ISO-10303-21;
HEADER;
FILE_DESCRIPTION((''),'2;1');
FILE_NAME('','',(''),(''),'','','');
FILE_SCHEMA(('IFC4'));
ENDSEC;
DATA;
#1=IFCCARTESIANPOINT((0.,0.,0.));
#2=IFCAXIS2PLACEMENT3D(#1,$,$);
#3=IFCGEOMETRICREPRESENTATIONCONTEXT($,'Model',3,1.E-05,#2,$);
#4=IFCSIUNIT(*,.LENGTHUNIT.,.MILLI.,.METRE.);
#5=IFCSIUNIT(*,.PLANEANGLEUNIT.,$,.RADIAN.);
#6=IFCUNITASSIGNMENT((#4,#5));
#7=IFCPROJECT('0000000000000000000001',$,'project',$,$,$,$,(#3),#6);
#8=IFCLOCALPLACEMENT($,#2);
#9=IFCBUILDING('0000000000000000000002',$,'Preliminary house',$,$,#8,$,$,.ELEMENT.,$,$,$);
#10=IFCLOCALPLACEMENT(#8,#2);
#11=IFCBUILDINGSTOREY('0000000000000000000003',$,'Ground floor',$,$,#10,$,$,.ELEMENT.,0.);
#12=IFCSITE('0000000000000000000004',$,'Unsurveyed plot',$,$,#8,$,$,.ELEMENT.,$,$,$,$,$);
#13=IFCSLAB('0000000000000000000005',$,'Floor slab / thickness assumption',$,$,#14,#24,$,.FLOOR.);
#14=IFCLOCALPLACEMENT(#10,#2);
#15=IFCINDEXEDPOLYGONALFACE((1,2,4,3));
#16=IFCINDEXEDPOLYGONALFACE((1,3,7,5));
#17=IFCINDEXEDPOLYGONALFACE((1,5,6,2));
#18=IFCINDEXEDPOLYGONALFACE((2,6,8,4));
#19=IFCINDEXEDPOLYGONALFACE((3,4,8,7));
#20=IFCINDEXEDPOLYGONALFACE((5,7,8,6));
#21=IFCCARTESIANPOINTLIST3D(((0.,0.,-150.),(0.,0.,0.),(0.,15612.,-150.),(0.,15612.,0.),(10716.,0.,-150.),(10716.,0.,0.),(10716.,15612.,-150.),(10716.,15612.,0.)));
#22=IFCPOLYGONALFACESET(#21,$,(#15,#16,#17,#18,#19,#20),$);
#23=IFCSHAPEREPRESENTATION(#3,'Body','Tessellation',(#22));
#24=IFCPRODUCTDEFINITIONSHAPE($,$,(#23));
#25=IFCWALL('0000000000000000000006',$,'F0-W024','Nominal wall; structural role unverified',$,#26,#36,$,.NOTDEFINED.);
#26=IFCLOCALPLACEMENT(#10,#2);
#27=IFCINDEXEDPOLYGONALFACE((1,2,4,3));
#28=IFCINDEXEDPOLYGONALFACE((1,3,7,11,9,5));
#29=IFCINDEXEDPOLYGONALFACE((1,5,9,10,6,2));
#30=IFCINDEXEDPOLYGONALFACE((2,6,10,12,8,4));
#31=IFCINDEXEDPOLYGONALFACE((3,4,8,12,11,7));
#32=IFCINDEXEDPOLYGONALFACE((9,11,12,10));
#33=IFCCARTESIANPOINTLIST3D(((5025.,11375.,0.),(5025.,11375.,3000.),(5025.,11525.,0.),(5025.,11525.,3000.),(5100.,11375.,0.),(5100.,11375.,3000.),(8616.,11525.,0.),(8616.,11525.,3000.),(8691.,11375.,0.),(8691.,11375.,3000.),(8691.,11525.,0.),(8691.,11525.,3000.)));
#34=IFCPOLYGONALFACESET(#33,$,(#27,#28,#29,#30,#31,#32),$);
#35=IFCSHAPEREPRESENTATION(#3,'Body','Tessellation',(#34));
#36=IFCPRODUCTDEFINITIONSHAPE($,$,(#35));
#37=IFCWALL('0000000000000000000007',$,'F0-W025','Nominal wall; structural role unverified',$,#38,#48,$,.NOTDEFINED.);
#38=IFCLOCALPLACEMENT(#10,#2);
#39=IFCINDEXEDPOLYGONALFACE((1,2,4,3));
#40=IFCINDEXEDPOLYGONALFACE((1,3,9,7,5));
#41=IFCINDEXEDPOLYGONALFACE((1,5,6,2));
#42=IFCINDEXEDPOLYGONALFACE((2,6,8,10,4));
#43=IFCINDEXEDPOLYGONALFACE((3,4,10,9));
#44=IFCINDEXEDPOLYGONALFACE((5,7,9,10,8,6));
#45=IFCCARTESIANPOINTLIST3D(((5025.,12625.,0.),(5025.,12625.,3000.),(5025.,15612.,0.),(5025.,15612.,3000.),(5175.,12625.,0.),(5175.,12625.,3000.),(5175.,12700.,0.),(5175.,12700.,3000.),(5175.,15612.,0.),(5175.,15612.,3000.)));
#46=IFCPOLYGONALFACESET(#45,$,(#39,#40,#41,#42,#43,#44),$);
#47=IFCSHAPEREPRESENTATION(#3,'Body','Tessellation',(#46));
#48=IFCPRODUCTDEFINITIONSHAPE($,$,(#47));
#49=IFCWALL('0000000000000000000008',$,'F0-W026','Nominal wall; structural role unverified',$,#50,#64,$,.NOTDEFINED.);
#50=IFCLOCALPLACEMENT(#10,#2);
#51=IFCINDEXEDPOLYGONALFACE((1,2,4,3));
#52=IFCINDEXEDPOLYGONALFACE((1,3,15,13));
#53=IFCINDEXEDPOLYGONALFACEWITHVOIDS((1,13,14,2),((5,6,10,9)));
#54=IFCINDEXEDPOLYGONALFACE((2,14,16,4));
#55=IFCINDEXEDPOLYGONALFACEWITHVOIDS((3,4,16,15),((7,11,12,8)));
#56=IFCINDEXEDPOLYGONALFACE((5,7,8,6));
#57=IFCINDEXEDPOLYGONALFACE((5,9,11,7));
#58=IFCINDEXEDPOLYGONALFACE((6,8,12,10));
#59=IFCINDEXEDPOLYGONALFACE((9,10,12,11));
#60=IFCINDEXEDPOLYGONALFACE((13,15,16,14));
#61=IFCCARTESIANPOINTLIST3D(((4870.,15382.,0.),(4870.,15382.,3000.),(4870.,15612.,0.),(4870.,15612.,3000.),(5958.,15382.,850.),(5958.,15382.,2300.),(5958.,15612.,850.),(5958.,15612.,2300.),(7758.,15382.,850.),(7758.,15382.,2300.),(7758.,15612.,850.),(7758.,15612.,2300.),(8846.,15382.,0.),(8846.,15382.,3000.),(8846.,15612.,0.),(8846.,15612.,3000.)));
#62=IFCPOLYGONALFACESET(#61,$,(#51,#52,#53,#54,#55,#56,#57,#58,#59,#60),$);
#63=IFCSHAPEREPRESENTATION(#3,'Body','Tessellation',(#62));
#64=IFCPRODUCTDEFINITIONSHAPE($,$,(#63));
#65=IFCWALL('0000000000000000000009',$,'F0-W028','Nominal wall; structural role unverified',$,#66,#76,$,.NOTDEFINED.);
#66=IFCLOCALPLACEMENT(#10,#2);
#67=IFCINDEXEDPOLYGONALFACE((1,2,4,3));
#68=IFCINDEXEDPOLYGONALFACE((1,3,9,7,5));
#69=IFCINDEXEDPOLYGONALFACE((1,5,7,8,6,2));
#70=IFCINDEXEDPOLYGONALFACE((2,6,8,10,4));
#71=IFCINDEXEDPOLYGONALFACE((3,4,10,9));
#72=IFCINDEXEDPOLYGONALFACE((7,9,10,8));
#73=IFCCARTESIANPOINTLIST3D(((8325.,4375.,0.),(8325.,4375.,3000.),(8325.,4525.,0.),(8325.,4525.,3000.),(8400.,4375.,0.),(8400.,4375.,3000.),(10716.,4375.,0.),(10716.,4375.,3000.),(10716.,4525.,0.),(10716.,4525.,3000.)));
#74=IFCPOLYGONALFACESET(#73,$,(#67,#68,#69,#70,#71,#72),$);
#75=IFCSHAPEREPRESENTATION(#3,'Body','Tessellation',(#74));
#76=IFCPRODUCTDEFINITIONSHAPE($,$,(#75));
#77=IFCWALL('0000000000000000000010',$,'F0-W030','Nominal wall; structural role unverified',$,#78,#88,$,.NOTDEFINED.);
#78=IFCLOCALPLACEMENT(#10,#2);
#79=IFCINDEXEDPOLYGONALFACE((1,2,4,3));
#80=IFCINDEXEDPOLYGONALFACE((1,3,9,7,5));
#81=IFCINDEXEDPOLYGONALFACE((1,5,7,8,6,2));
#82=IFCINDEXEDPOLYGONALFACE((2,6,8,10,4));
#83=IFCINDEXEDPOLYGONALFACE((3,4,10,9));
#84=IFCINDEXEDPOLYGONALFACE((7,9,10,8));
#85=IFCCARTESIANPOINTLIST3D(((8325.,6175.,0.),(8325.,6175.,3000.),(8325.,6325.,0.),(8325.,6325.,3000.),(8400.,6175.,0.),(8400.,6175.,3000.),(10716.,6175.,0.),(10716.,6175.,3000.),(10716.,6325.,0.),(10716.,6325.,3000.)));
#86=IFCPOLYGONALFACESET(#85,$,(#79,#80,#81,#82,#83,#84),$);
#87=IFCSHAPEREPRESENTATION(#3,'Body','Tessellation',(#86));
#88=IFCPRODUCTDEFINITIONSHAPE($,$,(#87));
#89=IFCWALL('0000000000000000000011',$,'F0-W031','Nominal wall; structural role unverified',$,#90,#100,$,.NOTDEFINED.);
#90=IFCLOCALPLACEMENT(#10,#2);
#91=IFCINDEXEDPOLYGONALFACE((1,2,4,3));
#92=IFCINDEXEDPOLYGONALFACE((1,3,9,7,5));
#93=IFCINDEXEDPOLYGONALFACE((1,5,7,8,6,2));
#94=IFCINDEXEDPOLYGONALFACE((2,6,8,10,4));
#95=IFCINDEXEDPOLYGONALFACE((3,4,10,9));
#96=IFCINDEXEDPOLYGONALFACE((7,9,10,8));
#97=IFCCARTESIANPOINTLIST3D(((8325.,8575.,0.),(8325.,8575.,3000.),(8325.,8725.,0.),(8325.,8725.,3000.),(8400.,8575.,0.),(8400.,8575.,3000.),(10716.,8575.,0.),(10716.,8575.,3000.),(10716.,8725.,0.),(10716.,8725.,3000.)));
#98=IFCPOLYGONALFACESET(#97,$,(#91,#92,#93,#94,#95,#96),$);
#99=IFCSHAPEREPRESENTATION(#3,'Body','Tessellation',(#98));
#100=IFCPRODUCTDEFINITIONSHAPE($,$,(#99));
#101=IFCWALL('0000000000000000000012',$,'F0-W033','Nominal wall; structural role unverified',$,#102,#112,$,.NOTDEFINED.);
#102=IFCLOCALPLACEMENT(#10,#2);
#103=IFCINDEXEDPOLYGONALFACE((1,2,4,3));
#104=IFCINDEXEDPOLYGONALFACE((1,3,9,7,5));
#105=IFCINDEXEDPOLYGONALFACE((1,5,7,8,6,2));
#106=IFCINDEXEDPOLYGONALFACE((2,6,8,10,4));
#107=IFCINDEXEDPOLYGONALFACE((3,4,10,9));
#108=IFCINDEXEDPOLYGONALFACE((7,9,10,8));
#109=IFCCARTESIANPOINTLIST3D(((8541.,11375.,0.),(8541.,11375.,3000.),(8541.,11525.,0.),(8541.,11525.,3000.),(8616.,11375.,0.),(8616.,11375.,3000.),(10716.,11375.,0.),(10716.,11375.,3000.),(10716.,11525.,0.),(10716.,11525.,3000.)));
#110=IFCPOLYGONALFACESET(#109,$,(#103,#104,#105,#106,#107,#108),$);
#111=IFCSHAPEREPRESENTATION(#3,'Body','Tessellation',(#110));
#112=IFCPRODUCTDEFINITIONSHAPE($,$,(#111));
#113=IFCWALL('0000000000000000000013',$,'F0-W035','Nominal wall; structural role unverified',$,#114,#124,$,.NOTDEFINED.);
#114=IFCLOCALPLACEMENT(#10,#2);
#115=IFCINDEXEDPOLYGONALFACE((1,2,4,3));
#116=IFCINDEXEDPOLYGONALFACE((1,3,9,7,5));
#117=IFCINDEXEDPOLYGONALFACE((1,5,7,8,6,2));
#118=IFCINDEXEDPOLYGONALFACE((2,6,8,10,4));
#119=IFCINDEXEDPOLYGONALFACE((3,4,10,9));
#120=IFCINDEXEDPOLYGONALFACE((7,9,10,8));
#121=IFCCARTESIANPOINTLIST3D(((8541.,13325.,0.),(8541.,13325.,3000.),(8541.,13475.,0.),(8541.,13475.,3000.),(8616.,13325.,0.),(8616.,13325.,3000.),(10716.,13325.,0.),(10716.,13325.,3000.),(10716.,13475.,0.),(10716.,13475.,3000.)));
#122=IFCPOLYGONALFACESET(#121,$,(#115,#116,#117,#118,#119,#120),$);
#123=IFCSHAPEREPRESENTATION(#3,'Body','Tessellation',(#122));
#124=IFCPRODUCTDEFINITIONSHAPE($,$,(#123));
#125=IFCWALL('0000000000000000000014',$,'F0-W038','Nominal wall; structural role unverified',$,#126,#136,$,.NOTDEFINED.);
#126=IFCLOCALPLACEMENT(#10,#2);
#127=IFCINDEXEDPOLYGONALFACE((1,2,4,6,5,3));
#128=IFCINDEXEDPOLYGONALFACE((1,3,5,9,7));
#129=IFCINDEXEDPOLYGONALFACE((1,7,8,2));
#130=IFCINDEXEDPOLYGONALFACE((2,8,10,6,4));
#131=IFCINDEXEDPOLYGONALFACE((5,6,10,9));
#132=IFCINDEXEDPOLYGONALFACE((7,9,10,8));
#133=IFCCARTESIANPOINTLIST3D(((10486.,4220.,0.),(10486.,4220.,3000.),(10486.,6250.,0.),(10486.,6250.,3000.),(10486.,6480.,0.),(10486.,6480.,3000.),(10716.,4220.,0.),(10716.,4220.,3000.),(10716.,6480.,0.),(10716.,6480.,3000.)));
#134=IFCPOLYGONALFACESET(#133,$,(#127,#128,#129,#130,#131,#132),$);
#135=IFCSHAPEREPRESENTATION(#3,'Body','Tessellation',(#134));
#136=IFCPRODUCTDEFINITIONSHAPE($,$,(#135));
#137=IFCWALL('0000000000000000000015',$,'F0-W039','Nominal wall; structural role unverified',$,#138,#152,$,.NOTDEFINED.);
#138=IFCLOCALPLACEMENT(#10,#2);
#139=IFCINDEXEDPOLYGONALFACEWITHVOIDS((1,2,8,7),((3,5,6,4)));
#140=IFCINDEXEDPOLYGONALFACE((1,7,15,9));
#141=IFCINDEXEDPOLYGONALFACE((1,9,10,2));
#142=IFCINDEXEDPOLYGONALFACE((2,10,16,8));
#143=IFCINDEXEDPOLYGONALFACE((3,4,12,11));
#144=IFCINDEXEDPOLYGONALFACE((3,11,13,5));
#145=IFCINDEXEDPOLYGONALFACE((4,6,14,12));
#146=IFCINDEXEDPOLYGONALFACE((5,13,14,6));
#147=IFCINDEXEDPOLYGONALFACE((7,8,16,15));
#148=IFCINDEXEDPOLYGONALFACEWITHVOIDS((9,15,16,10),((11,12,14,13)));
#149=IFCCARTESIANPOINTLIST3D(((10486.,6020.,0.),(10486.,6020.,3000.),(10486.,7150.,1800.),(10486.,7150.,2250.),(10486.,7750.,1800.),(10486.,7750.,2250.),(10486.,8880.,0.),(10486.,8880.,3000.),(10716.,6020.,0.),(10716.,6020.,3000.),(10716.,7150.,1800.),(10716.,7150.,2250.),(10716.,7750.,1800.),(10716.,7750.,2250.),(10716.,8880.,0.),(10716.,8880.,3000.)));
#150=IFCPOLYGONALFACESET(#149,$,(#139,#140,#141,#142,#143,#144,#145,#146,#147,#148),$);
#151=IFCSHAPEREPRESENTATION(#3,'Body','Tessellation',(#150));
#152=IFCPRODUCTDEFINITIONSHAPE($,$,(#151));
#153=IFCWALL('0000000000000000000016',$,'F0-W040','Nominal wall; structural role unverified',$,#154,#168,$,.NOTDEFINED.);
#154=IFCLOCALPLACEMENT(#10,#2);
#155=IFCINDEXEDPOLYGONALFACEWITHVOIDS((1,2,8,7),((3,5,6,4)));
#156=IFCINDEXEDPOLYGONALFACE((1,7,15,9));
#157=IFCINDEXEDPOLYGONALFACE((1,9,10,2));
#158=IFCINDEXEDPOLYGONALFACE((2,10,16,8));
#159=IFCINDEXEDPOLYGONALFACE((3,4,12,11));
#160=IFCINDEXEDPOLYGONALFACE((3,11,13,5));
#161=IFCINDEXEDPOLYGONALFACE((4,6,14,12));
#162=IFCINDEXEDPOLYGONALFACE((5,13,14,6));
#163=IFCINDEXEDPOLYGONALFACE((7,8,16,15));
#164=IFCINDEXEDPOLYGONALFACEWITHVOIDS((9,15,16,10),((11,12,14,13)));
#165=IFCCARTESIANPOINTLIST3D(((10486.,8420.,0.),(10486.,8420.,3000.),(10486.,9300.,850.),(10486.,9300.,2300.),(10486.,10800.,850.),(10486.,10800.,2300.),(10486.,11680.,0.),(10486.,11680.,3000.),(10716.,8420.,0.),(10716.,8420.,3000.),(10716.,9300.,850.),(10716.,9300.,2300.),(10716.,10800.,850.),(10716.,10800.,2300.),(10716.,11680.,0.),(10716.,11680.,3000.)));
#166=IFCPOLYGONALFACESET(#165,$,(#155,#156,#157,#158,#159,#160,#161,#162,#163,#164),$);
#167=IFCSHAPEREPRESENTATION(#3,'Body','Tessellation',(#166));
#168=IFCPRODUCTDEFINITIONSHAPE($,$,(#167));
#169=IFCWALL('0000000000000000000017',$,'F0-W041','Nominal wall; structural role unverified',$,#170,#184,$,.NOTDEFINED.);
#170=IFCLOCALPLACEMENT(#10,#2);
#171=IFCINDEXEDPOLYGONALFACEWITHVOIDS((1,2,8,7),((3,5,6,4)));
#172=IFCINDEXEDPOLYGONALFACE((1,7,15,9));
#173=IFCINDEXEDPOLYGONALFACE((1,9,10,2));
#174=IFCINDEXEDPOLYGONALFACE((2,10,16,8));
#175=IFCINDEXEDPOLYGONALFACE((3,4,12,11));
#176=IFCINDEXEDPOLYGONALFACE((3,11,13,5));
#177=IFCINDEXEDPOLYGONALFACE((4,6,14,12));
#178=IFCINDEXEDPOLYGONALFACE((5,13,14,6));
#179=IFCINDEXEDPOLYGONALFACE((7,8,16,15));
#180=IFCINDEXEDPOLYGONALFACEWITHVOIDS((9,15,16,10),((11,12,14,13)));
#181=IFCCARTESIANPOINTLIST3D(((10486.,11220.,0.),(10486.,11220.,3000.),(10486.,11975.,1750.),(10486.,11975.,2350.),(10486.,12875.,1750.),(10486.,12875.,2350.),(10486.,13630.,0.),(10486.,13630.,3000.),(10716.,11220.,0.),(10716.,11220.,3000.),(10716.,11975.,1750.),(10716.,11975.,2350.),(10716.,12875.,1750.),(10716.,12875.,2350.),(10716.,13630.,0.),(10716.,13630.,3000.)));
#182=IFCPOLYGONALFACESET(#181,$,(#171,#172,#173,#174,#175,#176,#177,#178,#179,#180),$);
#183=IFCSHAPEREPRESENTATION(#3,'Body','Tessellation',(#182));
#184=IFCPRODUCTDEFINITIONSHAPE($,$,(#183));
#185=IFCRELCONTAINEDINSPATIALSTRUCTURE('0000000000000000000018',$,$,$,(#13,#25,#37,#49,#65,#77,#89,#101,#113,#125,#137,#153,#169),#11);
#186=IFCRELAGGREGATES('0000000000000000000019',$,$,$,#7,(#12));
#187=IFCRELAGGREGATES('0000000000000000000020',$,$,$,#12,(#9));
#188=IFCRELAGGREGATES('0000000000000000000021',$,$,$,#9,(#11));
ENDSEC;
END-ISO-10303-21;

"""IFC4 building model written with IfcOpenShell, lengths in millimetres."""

from ifc_helpers import new_model, si_unit, frame, origin, place, context, project, spatial, polyline, outline, extrude, element, save


model = new_model("IFC4")

# Units and contexts
model_context = context("Model", 3, precision=1e-05, world=origin())
ifc_project = project(units=[si_unit("LENGTHUNIT", "METRE", prefix="MILLI"), si_unit("PLANEANGLEUNIT", "RADIAN")], contexts=[model_context])

# Site, building, storey
placement_1 = place(None, origin())
site = spatial("IfcSite", under=ifc_project, at=placement_1, Name="Unsurveyed plot", CompositionType="ELEMENT")
building = spatial("IfcBuilding", under=site, at=placement_1, Name="Preliminary house", CompositionType="ELEMENT")
placement_2 = place(placement_1, origin())
storey = spatial("IfcBuildingStorey", under=building, at=placement_2, Name="Ground floor", CompositionType="ELEMENT", Elevation=0.0)

# Slab
element("IfcSlab", 1, at=placement_2, inside=storey, Name="Floor slab / thickness assumption", PredefinedType="FLOOR", context=model_context, shape_type="SweptSolid", body=[
    extrude(outline(polyline([(10716.0, 0.0), (10716.0, 15612.0), (0.0, 15612.0), (0.0, 0.0), (10716.0, 0.0)])), frame((0.0, 0.0, -150.0)), (0.0, 0.0, 1.0), 150.0),
])

# Walls
element("IfcWall", 2, at=placement_2, inside=storey, Name="F0-W024", Description="Nominal wall; structural role unverified", PredefinedType="NOTDEFINED", context=model_context, shape_type="SweptSolid", body=[
    extrude(outline(polyline([(8691.0, 11525.0), (8691.0, 11375.0), (5100.0, 11375.0), (5025.0, 11375.0), (5025.0, 11525.0), (8616.0, 11525.0), (8691.0, 11525.0)])), origin(), (0.0, 0.0, 1.0), 3000.0),
])
element("IfcWall", 3, at=placement_2, inside=storey, Name="F0-W025", Description="Nominal wall; structural role unverified", PredefinedType="NOTDEFINED", context=model_context, shape_type="SweptSolid", body=[
    extrude(outline(polyline([(5175.0, 12700.0), (5175.0, 12625.0), (5025.0, 12625.0), (5025.0, 15612.0), (5175.0, 15612.0), (5175.0, 12700.0)])), origin(), (0.0, 0.0, 1.0), 3000.0),
])

# Wall, opening
wall_1 = element("IfcWall", 4, at=placement_2, inside=storey, Name="F0-W026", Description="Nominal wall; structural role unverified", PredefinedType="NOTDEFINED", context=model_context, shape_type="SweptSolid", body=[
    extrude(outline(polyline([(8846.0, 15382.0), (5100.0, 15382.0), (4870.0, 15382.0), (4870.0, 15612.0), (8846.0, 15612.0), (8846.0, 15382.0)])), origin(), (0.0, 0.0, 1.0), 3000.0),
])
element("IfcOpeningElement", 5, at=placement_2, cuts=wall_1, PredefinedType="OPENING", context=model_context, shape_type="SweptSolid", body=[
    extrude(outline(polyline([(5958.0, 14967.0), (7758.0, 14967.0), (7758.0, 16027.0), (5958.0, 16027.0), (5958.0, 14967.0)])), frame((0.0, 0.0, 850.0)), (0.0, 0.0, 1.0), 1450.0),
])

# Wall
element("IfcWall", 6, at=placement_2, inside=storey, Name="F0-W028", Description="Nominal wall; structural role unverified", PredefinedType="NOTDEFINED", context=model_context, shape_type="SweptSolid", body=[
    extrude(outline(polyline([(8400.0, 4375.0), (8325.0, 4375.0), (8325.0, 4525.0), (10716.0, 4525.0), (10716.0, 4375.0), (8400.0, 4375.0)])), origin(), (0.0, 0.0, 1.0), 3000.0),
])

# Walls
element("IfcWall", 7, at=placement_2, inside=storey, Name="F0-W030", Description="Nominal wall; structural role unverified", PredefinedType="NOTDEFINED", context=model_context, shape_type="SweptSolid", body=[
    extrude(outline(polyline([(8400.0, 6175.0), (8325.0, 6175.0), (8325.0, 6325.0), (10716.0, 6325.0), (10716.0, 6175.0), (8400.0, 6175.0)])), origin(), (0.0, 0.0, 1.0), 3000.0),
])
element("IfcWall", 8, at=placement_2, inside=storey, Name="F0-W031", Description="Nominal wall; structural role unverified", PredefinedType="NOTDEFINED", context=model_context, shape_type="SweptSolid", body=[
    extrude(outline(polyline([(8400.0, 8575.0), (8325.0, 8575.0), (8325.0, 8725.0), (10716.0, 8725.0), (10716.0, 8575.0), (8400.0, 8575.0)])), origin(), (0.0, 0.0, 1.0), 3000.0),
])

# Wall
element("IfcWall", 9, at=placement_2, inside=storey, Name="F0-W033", Description="Nominal wall; structural role unverified", PredefinedType="NOTDEFINED", context=model_context, shape_type="SweptSolid", body=[
    extrude(outline(polyline([(8616.0, 11375.0), (8541.0, 11375.0), (8541.0, 11525.0), (10716.0, 11525.0), (10716.0, 11375.0), (8616.0, 11375.0)])), origin(), (0.0, 0.0, 1.0), 3000.0),
])

# Wall
element("IfcWall", 10, at=placement_2, inside=storey, Name="F0-W035", Description="Nominal wall; structural role unverified", PredefinedType="NOTDEFINED", context=model_context, shape_type="SweptSolid", body=[
    extrude(outline(polyline([(8616.0, 13325.0), (8541.0, 13325.0), (8541.0, 13475.0), (10716.0, 13475.0), (10716.0, 13325.0), (8616.0, 13325.0)])), origin(), (0.0, 0.0, 1.0), 3000.0),
])

# Wall
element("IfcWall", 11, at=placement_2, inside=storey, Name="F0-W038", Description="Nominal wall; structural role unverified", PredefinedType="NOTDEFINED", context=model_context, shape_type="SweptSolid", body=[
    extrude(outline(polyline([(10486.0, 6480.0), (10716.0, 6480.0), (10716.0, 4220.0), (10486.0, 4220.0), (10486.0, 6250.0), (10486.0, 6480.0)])), origin(), (0.0, 0.0, 1.0), 3000.0),
])

# Walls, openings
wall_2 = element("IfcWall", 12, at=placement_2, inside=storey, Name="F0-W039", Description="Nominal wall; structural role unverified", PredefinedType="NOTDEFINED", context=model_context, shape_type="SweptSolid", body=[
    extrude(outline(polyline([(10486.0, 8880.0), (10716.0, 8880.0), (10716.0, 6020.0), (10486.0, 6020.0), (10486.0, 8650.0), (10486.0, 8880.0)])), origin(), (0.0, 0.0, 1.0), 3000.0),
])
element("IfcOpeningElement", 13, at=placement_2, cuts=wall_2, PredefinedType="OPENING", context=model_context, shape_type="SweptSolid", body=[
    extrude(outline(polyline([(11131.0, 7150.0), (11131.0, 7750.0), (10071.0, 7750.0), (10071.0, 7150.0), (11131.0, 7150.0)])), frame((0.0, 0.0, 1800.0)), (0.0, 0.0, 1.0), 450.0),
])
wall_3 = element("IfcWall", 14, at=placement_2, inside=storey, Name="F0-W040", Description="Nominal wall; structural role unverified", PredefinedType="NOTDEFINED", context=model_context, shape_type="SweptSolid", body=[
    extrude(outline(polyline([(10486.0, 11680.0), (10716.0, 11680.0), (10716.0, 8420.0), (10486.0, 8420.0), (10486.0, 11450.0), (10486.0, 11680.0)])), origin(), (0.0, 0.0, 1.0), 3000.0),
])
element("IfcOpeningElement", 15, at=placement_2, cuts=wall_3, PredefinedType="OPENING", context=model_context, shape_type="SweptSolid", body=[
    extrude(outline(polyline([(11131.0, 9300.0), (11131.0, 10800.0), (10071.0, 10800.0), (10071.0, 9300.0), (11131.0, 9300.0)])), frame((0.0, 0.0, 850.0)), (0.0, 0.0, 1.0), 1450.0),
])
wall_4 = element("IfcWall", 16, at=placement_2, inside=storey, Name="F0-W041", Description="Nominal wall; structural role unverified", PredefinedType="NOTDEFINED", context=model_context, shape_type="SweptSolid", body=[
    extrude(outline(polyline([(10486.0, 13630.0), (10716.0, 13630.0), (10716.0, 11220.0), (10486.0, 11220.0), (10486.0, 13400.0), (10486.0, 13630.0)])), origin(), (0.0, 0.0, 1.0), 3000.0),
])
element("IfcOpeningElement", 17, at=placement_2, cuts=wall_4, PredefinedType="OPENING", context=model_context, shape_type="SweptSolid", body=[
    extrude(outline(polyline([(11131.0, 11975.0), (11131.0, 12875.0), (10071.0, 12875.0), (10071.0, 11975.0), (11131.0, 11975.0)])), frame((0.0, 0.0, 1750.0)), (0.0, 0.0, 1.0), 600.0),
])

save(model, "model.ifc")
